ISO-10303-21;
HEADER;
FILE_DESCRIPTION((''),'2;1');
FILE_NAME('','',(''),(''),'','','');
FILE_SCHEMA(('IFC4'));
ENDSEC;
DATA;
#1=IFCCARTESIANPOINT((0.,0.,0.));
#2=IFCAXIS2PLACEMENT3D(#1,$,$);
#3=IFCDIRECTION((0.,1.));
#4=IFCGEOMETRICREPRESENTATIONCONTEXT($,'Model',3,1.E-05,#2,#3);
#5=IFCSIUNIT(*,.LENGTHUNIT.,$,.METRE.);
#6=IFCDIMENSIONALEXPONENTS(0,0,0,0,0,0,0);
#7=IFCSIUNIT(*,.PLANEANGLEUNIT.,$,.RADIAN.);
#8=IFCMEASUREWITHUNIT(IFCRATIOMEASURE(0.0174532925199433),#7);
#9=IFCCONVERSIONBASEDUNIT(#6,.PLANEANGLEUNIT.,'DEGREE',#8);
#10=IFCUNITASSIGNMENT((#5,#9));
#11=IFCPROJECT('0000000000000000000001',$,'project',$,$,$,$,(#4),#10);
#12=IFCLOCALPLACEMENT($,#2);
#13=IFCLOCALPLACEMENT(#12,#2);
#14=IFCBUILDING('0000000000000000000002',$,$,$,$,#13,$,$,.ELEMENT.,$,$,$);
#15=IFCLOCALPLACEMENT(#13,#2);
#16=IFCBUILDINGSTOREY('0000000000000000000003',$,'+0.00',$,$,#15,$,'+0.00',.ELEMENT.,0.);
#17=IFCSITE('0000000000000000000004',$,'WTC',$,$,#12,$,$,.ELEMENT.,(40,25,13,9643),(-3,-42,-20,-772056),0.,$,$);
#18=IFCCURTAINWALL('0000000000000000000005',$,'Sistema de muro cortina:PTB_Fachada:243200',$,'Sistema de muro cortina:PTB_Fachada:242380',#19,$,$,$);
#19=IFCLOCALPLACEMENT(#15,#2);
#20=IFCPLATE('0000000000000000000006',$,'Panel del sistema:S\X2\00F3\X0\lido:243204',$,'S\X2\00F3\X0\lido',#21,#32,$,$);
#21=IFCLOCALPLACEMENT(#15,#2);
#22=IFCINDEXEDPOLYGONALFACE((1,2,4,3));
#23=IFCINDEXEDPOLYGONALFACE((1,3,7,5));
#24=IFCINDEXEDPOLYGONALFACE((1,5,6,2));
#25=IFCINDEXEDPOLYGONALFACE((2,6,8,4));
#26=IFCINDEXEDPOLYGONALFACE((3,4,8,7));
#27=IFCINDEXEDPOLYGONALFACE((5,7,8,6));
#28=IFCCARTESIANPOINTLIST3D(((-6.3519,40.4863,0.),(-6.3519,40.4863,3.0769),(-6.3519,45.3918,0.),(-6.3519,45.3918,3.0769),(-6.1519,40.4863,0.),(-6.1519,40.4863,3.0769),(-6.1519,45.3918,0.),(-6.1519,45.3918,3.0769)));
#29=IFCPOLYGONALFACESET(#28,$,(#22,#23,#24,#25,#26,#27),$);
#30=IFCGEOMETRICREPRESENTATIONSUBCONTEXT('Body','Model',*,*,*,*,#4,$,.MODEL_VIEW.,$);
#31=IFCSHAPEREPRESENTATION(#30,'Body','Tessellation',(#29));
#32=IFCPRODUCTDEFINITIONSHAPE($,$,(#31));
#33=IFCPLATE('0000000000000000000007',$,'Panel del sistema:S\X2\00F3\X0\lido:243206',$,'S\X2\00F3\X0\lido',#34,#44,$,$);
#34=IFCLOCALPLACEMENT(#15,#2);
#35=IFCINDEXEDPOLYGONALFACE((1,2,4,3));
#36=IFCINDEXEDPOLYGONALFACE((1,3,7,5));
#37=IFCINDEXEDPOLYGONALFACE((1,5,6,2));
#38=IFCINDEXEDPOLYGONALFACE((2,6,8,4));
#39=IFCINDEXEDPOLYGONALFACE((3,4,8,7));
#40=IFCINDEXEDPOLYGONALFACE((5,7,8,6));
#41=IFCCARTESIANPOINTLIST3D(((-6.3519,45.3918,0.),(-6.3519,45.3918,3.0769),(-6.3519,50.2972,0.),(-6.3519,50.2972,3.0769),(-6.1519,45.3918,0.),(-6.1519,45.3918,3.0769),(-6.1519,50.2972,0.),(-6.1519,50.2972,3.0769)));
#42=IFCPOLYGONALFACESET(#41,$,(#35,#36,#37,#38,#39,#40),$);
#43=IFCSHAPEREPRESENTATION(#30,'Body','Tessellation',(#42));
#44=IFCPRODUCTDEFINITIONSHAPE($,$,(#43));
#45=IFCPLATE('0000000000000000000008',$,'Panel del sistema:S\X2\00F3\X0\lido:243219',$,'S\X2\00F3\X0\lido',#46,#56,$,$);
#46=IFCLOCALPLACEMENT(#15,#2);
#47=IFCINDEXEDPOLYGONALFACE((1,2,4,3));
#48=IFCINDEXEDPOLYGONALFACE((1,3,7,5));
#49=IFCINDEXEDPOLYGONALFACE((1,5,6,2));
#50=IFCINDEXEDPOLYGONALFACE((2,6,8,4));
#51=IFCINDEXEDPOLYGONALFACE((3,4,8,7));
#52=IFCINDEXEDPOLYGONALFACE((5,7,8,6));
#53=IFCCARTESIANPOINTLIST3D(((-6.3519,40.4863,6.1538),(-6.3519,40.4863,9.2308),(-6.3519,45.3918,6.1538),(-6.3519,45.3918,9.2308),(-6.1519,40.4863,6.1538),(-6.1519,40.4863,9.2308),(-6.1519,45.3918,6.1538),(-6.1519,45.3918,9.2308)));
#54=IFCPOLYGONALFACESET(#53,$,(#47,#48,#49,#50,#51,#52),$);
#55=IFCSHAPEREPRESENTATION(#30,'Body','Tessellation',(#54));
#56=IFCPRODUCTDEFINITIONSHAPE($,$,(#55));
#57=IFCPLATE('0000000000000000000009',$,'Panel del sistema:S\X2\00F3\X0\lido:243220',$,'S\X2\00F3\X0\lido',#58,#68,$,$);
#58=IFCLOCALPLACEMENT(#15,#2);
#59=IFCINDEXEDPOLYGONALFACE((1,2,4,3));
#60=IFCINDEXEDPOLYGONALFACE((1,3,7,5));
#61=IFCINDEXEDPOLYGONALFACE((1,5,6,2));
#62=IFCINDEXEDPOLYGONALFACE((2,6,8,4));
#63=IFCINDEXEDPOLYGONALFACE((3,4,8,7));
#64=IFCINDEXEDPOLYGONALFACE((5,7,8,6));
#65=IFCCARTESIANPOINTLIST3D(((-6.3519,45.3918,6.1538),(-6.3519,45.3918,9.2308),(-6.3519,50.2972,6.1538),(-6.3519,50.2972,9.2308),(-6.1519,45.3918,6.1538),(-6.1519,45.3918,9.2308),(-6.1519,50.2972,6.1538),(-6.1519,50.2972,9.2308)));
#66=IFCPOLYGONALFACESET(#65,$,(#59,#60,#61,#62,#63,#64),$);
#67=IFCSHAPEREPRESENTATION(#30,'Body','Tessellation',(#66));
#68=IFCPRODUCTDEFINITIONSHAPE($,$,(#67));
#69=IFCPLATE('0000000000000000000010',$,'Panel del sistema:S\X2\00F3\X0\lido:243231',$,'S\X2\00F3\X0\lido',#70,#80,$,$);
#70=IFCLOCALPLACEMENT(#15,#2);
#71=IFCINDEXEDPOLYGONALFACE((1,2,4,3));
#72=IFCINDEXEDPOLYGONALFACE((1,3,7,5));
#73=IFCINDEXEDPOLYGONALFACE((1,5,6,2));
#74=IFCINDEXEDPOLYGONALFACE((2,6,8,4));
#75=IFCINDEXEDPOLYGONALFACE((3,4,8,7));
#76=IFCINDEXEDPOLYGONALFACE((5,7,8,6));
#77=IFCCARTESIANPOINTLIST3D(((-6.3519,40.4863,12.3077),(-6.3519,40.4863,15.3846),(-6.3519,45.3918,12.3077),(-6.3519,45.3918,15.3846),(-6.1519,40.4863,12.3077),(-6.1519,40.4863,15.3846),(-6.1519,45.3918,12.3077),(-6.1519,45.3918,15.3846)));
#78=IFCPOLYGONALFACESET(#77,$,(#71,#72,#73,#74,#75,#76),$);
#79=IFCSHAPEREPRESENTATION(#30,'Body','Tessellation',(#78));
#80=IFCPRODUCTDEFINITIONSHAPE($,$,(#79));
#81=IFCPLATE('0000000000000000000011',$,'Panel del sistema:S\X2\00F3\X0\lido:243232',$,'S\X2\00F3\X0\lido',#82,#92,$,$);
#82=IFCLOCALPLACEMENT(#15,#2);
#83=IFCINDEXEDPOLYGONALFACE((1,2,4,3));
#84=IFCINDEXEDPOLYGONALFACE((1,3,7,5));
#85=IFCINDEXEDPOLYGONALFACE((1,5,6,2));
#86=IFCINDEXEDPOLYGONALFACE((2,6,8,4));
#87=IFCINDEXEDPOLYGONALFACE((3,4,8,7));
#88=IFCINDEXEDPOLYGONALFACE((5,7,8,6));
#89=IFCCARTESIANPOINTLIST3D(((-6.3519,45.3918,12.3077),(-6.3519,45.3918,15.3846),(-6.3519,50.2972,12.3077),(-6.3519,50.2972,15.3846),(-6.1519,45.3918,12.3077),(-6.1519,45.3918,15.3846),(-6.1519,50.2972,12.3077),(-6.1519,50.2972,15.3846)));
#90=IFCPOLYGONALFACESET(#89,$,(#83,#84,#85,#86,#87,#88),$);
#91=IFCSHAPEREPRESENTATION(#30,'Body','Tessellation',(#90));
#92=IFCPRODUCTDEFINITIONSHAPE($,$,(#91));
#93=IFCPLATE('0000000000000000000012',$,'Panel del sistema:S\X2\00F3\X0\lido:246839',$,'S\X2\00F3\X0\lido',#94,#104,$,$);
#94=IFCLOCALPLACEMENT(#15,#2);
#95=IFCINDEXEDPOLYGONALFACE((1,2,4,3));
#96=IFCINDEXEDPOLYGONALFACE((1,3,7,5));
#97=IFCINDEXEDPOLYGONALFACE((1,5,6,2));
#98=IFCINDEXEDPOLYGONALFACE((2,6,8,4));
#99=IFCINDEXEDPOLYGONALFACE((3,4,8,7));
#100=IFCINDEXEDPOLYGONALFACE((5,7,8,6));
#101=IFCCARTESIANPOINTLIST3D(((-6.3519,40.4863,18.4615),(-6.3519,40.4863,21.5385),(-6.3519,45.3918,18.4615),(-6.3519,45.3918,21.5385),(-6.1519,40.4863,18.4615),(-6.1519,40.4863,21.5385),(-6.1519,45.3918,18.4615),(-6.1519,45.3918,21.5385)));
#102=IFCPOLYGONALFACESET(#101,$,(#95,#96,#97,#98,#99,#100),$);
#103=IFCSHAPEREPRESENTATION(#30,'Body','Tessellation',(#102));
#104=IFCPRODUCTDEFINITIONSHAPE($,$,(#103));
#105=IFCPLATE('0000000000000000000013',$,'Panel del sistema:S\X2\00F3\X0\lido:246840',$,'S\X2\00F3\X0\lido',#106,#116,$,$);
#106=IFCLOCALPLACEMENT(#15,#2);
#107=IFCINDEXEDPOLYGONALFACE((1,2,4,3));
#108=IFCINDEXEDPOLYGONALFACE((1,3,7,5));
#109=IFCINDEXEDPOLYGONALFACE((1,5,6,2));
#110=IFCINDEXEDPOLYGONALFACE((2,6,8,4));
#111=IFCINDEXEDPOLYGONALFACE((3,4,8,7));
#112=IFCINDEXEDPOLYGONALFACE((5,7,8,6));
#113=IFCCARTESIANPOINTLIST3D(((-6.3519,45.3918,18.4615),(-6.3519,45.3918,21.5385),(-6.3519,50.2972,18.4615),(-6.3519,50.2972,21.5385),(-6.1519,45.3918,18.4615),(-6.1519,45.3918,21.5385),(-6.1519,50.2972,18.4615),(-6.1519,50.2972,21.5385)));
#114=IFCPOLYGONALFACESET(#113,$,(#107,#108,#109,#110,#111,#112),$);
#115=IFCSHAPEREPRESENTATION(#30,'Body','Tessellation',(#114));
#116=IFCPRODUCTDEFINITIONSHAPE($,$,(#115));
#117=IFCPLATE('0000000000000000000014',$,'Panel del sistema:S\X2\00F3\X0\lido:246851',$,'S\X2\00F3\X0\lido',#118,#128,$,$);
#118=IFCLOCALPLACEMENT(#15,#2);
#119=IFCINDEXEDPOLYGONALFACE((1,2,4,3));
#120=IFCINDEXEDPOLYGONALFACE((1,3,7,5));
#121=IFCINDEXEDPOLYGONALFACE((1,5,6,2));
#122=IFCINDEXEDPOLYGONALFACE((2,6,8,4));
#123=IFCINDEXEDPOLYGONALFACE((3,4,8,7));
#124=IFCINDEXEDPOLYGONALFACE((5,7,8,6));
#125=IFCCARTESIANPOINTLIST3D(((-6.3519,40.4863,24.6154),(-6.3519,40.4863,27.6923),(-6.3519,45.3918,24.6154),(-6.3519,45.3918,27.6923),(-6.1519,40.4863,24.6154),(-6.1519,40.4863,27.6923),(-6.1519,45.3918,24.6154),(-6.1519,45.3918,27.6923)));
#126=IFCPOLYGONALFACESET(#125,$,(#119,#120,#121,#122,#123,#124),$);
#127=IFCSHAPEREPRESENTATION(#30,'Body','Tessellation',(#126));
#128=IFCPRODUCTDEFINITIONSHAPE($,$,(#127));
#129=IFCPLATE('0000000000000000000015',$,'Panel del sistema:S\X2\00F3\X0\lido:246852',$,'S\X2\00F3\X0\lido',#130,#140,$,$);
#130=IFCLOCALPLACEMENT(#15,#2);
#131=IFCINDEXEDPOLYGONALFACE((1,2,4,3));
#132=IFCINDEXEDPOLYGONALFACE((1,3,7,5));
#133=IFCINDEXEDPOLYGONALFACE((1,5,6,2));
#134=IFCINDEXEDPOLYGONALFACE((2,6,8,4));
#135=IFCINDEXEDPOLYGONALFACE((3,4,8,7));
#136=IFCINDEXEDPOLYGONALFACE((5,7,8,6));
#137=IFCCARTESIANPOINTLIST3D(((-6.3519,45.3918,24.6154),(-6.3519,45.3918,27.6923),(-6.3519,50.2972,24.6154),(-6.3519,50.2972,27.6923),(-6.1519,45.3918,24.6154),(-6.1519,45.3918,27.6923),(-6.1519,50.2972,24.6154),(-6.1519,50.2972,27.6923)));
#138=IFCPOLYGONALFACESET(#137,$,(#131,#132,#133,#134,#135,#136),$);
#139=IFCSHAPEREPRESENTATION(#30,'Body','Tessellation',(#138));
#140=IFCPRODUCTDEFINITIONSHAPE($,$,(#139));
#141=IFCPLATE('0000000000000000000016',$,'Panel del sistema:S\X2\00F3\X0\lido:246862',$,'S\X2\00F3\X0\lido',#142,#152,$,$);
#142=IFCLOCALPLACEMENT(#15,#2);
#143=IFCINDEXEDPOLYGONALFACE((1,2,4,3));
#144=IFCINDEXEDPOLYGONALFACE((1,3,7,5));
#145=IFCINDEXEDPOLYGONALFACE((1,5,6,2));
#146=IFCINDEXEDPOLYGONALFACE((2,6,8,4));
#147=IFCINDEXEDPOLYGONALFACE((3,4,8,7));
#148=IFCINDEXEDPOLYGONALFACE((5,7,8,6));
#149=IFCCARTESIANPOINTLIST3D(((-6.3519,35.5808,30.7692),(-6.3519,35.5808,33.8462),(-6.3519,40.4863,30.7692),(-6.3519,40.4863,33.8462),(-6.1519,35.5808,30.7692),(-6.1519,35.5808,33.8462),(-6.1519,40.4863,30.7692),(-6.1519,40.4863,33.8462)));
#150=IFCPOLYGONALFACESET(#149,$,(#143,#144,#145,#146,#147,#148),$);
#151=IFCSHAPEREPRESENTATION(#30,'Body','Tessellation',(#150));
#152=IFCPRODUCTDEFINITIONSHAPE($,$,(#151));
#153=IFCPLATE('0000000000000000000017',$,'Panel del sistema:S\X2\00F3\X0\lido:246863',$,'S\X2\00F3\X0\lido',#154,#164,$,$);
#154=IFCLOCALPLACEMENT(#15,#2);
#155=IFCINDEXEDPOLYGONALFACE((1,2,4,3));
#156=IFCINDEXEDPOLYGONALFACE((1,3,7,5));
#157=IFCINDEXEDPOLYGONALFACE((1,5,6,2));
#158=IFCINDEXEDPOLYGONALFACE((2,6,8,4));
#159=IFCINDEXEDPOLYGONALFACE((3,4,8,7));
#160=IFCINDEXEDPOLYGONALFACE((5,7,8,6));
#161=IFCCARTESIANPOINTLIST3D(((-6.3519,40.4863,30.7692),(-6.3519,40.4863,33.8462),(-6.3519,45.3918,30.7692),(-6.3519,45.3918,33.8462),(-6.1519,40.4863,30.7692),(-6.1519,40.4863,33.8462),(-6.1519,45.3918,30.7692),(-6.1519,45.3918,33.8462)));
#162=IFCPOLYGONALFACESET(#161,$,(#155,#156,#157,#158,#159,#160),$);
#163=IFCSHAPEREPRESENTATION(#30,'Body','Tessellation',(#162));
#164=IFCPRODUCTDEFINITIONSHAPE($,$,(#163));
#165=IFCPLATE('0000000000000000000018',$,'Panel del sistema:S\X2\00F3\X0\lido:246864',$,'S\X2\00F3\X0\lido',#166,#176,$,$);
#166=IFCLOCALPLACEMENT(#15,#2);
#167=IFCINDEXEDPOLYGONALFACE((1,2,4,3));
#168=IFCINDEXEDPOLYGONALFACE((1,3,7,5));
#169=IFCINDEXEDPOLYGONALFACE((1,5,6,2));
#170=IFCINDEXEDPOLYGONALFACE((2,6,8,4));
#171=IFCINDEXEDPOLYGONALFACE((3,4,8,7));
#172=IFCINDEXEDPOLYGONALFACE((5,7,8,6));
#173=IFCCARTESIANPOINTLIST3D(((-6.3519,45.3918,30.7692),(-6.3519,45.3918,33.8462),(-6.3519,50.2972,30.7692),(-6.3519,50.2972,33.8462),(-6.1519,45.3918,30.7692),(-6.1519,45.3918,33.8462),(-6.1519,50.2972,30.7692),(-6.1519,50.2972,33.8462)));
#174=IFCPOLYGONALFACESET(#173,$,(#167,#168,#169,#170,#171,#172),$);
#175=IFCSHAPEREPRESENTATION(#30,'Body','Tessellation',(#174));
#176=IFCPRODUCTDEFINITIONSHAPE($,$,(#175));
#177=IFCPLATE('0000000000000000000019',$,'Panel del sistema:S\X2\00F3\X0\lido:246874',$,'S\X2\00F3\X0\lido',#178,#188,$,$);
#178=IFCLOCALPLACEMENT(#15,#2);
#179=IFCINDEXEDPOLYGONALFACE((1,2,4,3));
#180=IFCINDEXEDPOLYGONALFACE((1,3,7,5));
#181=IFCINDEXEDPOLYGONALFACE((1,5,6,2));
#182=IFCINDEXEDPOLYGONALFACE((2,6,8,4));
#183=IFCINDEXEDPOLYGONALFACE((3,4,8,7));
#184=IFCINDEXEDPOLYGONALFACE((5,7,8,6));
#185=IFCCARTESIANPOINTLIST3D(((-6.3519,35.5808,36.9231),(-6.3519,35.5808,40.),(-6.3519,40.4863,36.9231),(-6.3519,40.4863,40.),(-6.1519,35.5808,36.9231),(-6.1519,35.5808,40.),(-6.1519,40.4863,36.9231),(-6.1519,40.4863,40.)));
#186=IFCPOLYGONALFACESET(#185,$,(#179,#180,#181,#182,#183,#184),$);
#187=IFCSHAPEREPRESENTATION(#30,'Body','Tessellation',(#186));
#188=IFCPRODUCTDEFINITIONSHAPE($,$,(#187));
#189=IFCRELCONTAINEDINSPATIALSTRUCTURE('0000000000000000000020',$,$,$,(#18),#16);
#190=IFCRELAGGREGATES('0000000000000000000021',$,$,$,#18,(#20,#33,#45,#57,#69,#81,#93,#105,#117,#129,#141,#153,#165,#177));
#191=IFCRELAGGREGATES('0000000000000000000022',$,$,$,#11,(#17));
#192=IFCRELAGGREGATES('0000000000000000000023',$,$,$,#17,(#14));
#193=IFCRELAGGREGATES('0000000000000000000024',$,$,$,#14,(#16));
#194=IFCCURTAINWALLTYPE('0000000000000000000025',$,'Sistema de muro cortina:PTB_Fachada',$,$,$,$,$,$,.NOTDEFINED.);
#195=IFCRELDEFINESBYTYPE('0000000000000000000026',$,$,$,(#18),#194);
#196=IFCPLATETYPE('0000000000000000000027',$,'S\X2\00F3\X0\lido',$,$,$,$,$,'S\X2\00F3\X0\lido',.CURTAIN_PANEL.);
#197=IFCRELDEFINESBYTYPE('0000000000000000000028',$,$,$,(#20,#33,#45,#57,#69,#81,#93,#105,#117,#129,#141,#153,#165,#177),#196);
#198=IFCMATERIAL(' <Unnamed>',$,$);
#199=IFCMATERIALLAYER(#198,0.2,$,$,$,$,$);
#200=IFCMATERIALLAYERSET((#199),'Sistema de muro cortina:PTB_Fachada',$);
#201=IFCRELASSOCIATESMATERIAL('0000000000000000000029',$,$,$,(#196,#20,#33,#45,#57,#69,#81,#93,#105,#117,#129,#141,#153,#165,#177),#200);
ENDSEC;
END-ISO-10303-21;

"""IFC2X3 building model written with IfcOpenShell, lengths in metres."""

from ifc_helpers import new_model, entity, si_unit, converted_unit, direction, frame, origin, origin_2d_with_axis, place, context, subcontext, project, spatial, rectangle, extrude, source, transform, mapped, material, layer, layer_set, layer_usage, type_object, type_shapes, element, aggregate, save


model = new_model("IFC2X3")

# Units and contexts
model_context = context("Model", 3, precision=1e-05, world=origin(), true_north=direction((0.0, 1.0)))
body_context = subcontext(model_context, "Body", "Model", "MODEL_VIEW")
ifc_project = project(units=[si_unit("LENGTHUNIT", "METRE"), converted_unit("PLANEANGLEUNIT", "DEGREE", entity("IfcRatioMeasure", 0.0174532925199433), si_unit("PLANEANGLEUNIT", "RADIAN"), dimensions=[0, 0, 0, 0, 0, 0, 0])], contexts=[model_context])

# Site, building, storey
site_placement = place(None, origin())
site = spatial("IfcSite", under=ifc_project, at=site_placement, Name="WTC", CompositionType="ELEMENT", RefLatitude=(40, 25, 13, 9643), RefLongitude=(-3, -42, -20, -772056), RefElevation=0.0)
building_placement = place(site_placement, origin())
building = spatial("IfcBuilding", under=site, at=building_placement, CompositionType="ELEMENT")
storey_placement = place(building_placement, origin())
storey = spatial("IfcBuildingStorey", under=building, at=storey_placement, Name="+0.00", LongName="+0.00", CompositionType="ELEMENT", Elevation=0.0)

# Curtain wall, plates
curtain_wall_type = type_object("IfcCurtainWallType", Name="Sistema de muro cortina:PTB_Fachada", PredefinedType="NOTDEFINED")
curtain_wall_1_placement = place(storey_placement, origin())
curtain_wall_1 = element("IfcCurtainWall", 1, at=curtain_wall_1_placement, inside=storey, type_object=curtain_wall_type, Name="Sistema de muro cortina:PTB_Fachada:243200", ObjectType="Sistema de muro cortina:PTB_Fachada:242380")
ifc_material_1 = material(Name=" <Unnamed>")
ifc_layer_1 = layer(ifc_material_1, 0.2)
ifc_layer_set_1 = layer_set([ifc_layer_1], Name="Sistema de muro cortina:PTB_Fachada")
ifc_layer_usage_1 = layer_usage(ifc_layer_set_1, "AXIS3", "POSITIVE", 0.0)
plate_type_1 = type_object("IfcPlateType", Name="Sólido", ElementType="Sólido", PredefinedType="CURTAIN_PANEL", material=ifc_layer_set_1)
shared_shape_1 = source(origin(), body_context, "Body", "SweptSolid", [
    extrude(rectangle(XDim=0.2, YDim=4.9055, at=origin_2d_with_axis()), frame((0.0, 0.0, 0.0), z_axis=(0.0, 0.0, 1.0), x_axis=(0.0, 1.0, 0.0)), (0.0, 0.0, 1.0), 3.0769),
])
type_shapes(plate_type_1, [shared_shape_1])
plate_1_placement = place(curtain_wall_1_placement, frame((-6.2519, 42.939, 0.0), z_axis=(0.0, 0.0, 1.0), x_axis=(0.0, 1.0, 0.0)))
plate_1 = element("IfcPlate", 2, at=plate_1_placement, type_object=plate_type_1, material=ifc_layer_usage_1, Name="Panel del sistema:Sólido:243204", ObjectType="Sólido", context=body_context, shape_type="MappedRepresentation", body=[
    mapped(shared_shape_1, transform((0.0, 0.0, 0.0), scale=1.0)),
])
ifc_layer_usage_2 = layer_usage(ifc_layer_set_1, "AXIS3", "POSITIVE", 0.0)
plate_2_placement = place(curtain_wall_1_placement, frame((-6.2519, 47.8445, 0.0), z_axis=(0.0, 0.0, 1.0), x_axis=(0.0, 1.0, 0.0)))
plate_2 = element("IfcPlate", 3, at=plate_2_placement, type_object=plate_type_1, material=ifc_layer_usage_2, Name="Panel del sistema:Sólido:243206", ObjectType="Sólido", context=body_context, shape_type="MappedRepresentation", body=[
    mapped(shared_shape_1, transform((0.0, 0.0, 0.0), scale=1.0)),
])
ifc_layer_usage_3 = layer_usage(ifc_layer_set_1, "AXIS3", "POSITIVE", 0.0)
plate_3_placement = place(curtain_wall_1_placement, frame((-6.2519, 42.939, 6.1538), z_axis=(0.0, 0.0, 1.0), x_axis=(0.0, 1.0, 0.0)))
plate_3 = element("IfcPlate", 4, at=plate_3_placement, type_object=plate_type_1, material=ifc_layer_usage_3, Name="Panel del sistema:Sólido:243219", ObjectType="Sólido", context=body_context, shape_type="MappedRepresentation", body=[
    mapped(shared_shape_1, transform((0.0, 0.0, 0.0), scale=1.0)),
])
ifc_layer_usage_4 = layer_usage(ifc_layer_set_1, "AXIS3", "POSITIVE", 0.0)
plate_4_placement = place(curtain_wall_1_placement, frame((-6.2519, 47.8445, 6.1538), z_axis=(0.0, 0.0, 1.0), x_axis=(0.0, 1.0, 0.0)))
plate_4 = element("IfcPlate", 5, at=plate_4_placement, type_object=plate_type_1, material=ifc_layer_usage_4, Name="Panel del sistema:Sólido:243220", ObjectType="Sólido", context=body_context, shape_type="MappedRepresentation", body=[
    mapped(shared_shape_1, transform((0.0, 0.0, 0.0), scale=1.0)),
])
ifc_layer_usage_5 = layer_usage(ifc_layer_set_1, "AXIS3", "POSITIVE", 0.0)
plate_5_placement = place(curtain_wall_1_placement, frame((-6.2519, 42.939, 12.3077), z_axis=(0.0, 0.0, 1.0), x_axis=(0.0, 1.0, 0.0)))
plate_5 = element("IfcPlate", 6, at=plate_5_placement, type_object=plate_type_1, material=ifc_layer_usage_5, Name="Panel del sistema:Sólido:243231", ObjectType="Sólido", context=body_context, shape_type="MappedRepresentation", body=[
    mapped(shared_shape_1, transform((0.0, 0.0, 0.0), scale=1.0)),
])
ifc_layer_usage_6 = layer_usage(ifc_layer_set_1, "AXIS3", "POSITIVE", 0.0)
plate_6_placement = place(curtain_wall_1_placement, frame((-6.2519, 47.8445, 12.3077), z_axis=(0.0, 0.0, 1.0), x_axis=(0.0, 1.0, 0.0)))
plate_6 = element("IfcPlate", 7, at=plate_6_placement, type_object=plate_type_1, material=ifc_layer_usage_6, Name="Panel del sistema:Sólido:243232", ObjectType="Sólido", context=body_context, shape_type="MappedRepresentation", body=[
    mapped(shared_shape_1, transform((0.0, 0.0, 0.0), scale=1.0)),
])
ifc_layer_usage_7 = layer_usage(ifc_layer_set_1, "AXIS3", "POSITIVE", 0.0)
plate_7_placement = place(curtain_wall_1_placement, frame((-6.2519, 42.939, 18.4615), z_axis=(0.0, 0.0, 1.0), x_axis=(0.0, 1.0, 0.0)))
plate_7 = element("IfcPlate", 8, at=plate_7_placement, type_object=plate_type_1, material=ifc_layer_usage_7, Name="Panel del sistema:Sólido:246839", ObjectType="Sólido", context=body_context, shape_type="MappedRepresentation", body=[
    mapped(shared_shape_1, transform((0.0, 0.0, 0.0), scale=1.0)),
])
ifc_layer_usage_8 = layer_usage(ifc_layer_set_1, "AXIS3", "POSITIVE", 0.0)
plate_8_placement = place(curtain_wall_1_placement, frame((-6.2519, 47.8445, 18.4615), z_axis=(0.0, 0.0, 1.0), x_axis=(0.0, 1.0, 0.0)))
plate_8 = element("IfcPlate", 9, at=plate_8_placement, type_object=plate_type_1, material=ifc_layer_usage_8, Name="Panel del sistema:Sólido:246840", ObjectType="Sólido", context=body_context, shape_type="MappedRepresentation", body=[
    mapped(shared_shape_1, transform((0.0, 0.0, 0.0), scale=1.0)),
])
ifc_layer_usage_9 = layer_usage(ifc_layer_set_1, "AXIS3", "POSITIVE", 0.0)
plate_9_placement = place(curtain_wall_1_placement, frame((-6.2519, 42.939, 24.6154), z_axis=(0.0, 0.0, 1.0), x_axis=(0.0, 1.0, 0.0)))
plate_9 = element("IfcPlate", 10, at=plate_9_placement, type_object=plate_type_1, material=ifc_layer_usage_9, Name="Panel del sistema:Sólido:246851", ObjectType="Sólido", context=body_context, shape_type="MappedRepresentation", body=[
    mapped(shared_shape_1, transform((0.0, 0.0, 0.0), scale=1.0)),
])
ifc_layer_usage_10 = layer_usage(ifc_layer_set_1, "AXIS3", "POSITIVE", 0.0)
plate_10_placement = place(curtain_wall_1_placement, frame((-6.2519, 47.8445, 24.6154), z_axis=(0.0, 0.0, 1.0), x_axis=(0.0, 1.0, 0.0)))
plate_10 = element("IfcPlate", 11, at=plate_10_placement, type_object=plate_type_1, material=ifc_layer_usage_10, Name="Panel del sistema:Sólido:246852", ObjectType="Sólido", context=body_context, shape_type="MappedRepresentation", body=[
    mapped(shared_shape_1, transform((0.0, 0.0, 0.0), scale=1.0)),
])
ifc_layer_usage_11 = layer_usage(ifc_layer_set_1, "AXIS3", "POSITIVE", 0.0)
plate_11_placement = place(curtain_wall_1_placement, frame((-6.2519, 38.0336, 30.7692), z_axis=(0.0, 0.0, 1.0), x_axis=(0.0, 1.0, 0.0)))
plate_11 = element("IfcPlate", 12, at=plate_11_placement, type_object=plate_type_1, material=ifc_layer_usage_11, Name="Panel del sistema:Sólido:246862", ObjectType="Sólido", context=body_context, shape_type="MappedRepresentation", body=[
    mapped(shared_shape_1, transform((0.0, 0.0, 0.0), scale=1.0)),
])
ifc_layer_usage_12 = layer_usage(ifc_layer_set_1, "AXIS3", "POSITIVE", 0.0)
plate_12_placement = place(curtain_wall_1_placement, frame((-6.2519, 42.939, 30.7692), z_axis=(0.0, 0.0, 1.0), x_axis=(0.0, 1.0, 0.0)))
plate_12 = element("IfcPlate", 13, at=plate_12_placement, type_object=plate_type_1, material=ifc_layer_usage_12, Name="Panel del sistema:Sólido:246863", ObjectType="Sólido", context=body_context, shape_type="MappedRepresentation", body=[
    mapped(shared_shape_1, transform((0.0, 0.0, 0.0), scale=1.0)),
])
ifc_layer_usage_13 = layer_usage(ifc_layer_set_1, "AXIS3", "POSITIVE", 0.0)
plate_13_placement = place(curtain_wall_1_placement, frame((-6.2519, 47.8445, 30.7692), z_axis=(0.0, 0.0, 1.0), x_axis=(0.0, 1.0, 0.0)))
plate_13 = element("IfcPlate", 14, at=plate_13_placement, type_object=plate_type_1, material=ifc_layer_usage_13, Name="Panel del sistema:Sólido:246864", ObjectType="Sólido", context=body_context, shape_type="MappedRepresentation", body=[
    mapped(shared_shape_1, transform((0.0, 0.0, 0.0), scale=1.0)),
])
ifc_layer_usage_14 = layer_usage(ifc_layer_set_1, "AXIS3", "POSITIVE", 0.0)
plate_14_placement = place(curtain_wall_1_placement, frame((-6.2519, 38.0336, 36.9231), z_axis=(0.0, 0.0, 1.0), x_axis=(0.0, 1.0, 0.0)))
plate_14 = element("IfcPlate", 15, at=plate_14_placement, type_object=plate_type_1, material=ifc_layer_usage_14, Name="Panel del sistema:Sólido:246874", ObjectType="Sólido", context=body_context, shape_type="MappedRepresentation", body=[
    mapped(shared_shape_1, transform((0.0, 0.0, 0.0), scale=1.0)),
])
aggregate(curtain_wall_1, [plate_1, plate_2, plate_3, plate_4, plate_5, plate_6, plate_7, plate_8, plate_9, plate_10, plate_11, plate_12, plate_13, plate_14])

save(model, "model.ifc")
